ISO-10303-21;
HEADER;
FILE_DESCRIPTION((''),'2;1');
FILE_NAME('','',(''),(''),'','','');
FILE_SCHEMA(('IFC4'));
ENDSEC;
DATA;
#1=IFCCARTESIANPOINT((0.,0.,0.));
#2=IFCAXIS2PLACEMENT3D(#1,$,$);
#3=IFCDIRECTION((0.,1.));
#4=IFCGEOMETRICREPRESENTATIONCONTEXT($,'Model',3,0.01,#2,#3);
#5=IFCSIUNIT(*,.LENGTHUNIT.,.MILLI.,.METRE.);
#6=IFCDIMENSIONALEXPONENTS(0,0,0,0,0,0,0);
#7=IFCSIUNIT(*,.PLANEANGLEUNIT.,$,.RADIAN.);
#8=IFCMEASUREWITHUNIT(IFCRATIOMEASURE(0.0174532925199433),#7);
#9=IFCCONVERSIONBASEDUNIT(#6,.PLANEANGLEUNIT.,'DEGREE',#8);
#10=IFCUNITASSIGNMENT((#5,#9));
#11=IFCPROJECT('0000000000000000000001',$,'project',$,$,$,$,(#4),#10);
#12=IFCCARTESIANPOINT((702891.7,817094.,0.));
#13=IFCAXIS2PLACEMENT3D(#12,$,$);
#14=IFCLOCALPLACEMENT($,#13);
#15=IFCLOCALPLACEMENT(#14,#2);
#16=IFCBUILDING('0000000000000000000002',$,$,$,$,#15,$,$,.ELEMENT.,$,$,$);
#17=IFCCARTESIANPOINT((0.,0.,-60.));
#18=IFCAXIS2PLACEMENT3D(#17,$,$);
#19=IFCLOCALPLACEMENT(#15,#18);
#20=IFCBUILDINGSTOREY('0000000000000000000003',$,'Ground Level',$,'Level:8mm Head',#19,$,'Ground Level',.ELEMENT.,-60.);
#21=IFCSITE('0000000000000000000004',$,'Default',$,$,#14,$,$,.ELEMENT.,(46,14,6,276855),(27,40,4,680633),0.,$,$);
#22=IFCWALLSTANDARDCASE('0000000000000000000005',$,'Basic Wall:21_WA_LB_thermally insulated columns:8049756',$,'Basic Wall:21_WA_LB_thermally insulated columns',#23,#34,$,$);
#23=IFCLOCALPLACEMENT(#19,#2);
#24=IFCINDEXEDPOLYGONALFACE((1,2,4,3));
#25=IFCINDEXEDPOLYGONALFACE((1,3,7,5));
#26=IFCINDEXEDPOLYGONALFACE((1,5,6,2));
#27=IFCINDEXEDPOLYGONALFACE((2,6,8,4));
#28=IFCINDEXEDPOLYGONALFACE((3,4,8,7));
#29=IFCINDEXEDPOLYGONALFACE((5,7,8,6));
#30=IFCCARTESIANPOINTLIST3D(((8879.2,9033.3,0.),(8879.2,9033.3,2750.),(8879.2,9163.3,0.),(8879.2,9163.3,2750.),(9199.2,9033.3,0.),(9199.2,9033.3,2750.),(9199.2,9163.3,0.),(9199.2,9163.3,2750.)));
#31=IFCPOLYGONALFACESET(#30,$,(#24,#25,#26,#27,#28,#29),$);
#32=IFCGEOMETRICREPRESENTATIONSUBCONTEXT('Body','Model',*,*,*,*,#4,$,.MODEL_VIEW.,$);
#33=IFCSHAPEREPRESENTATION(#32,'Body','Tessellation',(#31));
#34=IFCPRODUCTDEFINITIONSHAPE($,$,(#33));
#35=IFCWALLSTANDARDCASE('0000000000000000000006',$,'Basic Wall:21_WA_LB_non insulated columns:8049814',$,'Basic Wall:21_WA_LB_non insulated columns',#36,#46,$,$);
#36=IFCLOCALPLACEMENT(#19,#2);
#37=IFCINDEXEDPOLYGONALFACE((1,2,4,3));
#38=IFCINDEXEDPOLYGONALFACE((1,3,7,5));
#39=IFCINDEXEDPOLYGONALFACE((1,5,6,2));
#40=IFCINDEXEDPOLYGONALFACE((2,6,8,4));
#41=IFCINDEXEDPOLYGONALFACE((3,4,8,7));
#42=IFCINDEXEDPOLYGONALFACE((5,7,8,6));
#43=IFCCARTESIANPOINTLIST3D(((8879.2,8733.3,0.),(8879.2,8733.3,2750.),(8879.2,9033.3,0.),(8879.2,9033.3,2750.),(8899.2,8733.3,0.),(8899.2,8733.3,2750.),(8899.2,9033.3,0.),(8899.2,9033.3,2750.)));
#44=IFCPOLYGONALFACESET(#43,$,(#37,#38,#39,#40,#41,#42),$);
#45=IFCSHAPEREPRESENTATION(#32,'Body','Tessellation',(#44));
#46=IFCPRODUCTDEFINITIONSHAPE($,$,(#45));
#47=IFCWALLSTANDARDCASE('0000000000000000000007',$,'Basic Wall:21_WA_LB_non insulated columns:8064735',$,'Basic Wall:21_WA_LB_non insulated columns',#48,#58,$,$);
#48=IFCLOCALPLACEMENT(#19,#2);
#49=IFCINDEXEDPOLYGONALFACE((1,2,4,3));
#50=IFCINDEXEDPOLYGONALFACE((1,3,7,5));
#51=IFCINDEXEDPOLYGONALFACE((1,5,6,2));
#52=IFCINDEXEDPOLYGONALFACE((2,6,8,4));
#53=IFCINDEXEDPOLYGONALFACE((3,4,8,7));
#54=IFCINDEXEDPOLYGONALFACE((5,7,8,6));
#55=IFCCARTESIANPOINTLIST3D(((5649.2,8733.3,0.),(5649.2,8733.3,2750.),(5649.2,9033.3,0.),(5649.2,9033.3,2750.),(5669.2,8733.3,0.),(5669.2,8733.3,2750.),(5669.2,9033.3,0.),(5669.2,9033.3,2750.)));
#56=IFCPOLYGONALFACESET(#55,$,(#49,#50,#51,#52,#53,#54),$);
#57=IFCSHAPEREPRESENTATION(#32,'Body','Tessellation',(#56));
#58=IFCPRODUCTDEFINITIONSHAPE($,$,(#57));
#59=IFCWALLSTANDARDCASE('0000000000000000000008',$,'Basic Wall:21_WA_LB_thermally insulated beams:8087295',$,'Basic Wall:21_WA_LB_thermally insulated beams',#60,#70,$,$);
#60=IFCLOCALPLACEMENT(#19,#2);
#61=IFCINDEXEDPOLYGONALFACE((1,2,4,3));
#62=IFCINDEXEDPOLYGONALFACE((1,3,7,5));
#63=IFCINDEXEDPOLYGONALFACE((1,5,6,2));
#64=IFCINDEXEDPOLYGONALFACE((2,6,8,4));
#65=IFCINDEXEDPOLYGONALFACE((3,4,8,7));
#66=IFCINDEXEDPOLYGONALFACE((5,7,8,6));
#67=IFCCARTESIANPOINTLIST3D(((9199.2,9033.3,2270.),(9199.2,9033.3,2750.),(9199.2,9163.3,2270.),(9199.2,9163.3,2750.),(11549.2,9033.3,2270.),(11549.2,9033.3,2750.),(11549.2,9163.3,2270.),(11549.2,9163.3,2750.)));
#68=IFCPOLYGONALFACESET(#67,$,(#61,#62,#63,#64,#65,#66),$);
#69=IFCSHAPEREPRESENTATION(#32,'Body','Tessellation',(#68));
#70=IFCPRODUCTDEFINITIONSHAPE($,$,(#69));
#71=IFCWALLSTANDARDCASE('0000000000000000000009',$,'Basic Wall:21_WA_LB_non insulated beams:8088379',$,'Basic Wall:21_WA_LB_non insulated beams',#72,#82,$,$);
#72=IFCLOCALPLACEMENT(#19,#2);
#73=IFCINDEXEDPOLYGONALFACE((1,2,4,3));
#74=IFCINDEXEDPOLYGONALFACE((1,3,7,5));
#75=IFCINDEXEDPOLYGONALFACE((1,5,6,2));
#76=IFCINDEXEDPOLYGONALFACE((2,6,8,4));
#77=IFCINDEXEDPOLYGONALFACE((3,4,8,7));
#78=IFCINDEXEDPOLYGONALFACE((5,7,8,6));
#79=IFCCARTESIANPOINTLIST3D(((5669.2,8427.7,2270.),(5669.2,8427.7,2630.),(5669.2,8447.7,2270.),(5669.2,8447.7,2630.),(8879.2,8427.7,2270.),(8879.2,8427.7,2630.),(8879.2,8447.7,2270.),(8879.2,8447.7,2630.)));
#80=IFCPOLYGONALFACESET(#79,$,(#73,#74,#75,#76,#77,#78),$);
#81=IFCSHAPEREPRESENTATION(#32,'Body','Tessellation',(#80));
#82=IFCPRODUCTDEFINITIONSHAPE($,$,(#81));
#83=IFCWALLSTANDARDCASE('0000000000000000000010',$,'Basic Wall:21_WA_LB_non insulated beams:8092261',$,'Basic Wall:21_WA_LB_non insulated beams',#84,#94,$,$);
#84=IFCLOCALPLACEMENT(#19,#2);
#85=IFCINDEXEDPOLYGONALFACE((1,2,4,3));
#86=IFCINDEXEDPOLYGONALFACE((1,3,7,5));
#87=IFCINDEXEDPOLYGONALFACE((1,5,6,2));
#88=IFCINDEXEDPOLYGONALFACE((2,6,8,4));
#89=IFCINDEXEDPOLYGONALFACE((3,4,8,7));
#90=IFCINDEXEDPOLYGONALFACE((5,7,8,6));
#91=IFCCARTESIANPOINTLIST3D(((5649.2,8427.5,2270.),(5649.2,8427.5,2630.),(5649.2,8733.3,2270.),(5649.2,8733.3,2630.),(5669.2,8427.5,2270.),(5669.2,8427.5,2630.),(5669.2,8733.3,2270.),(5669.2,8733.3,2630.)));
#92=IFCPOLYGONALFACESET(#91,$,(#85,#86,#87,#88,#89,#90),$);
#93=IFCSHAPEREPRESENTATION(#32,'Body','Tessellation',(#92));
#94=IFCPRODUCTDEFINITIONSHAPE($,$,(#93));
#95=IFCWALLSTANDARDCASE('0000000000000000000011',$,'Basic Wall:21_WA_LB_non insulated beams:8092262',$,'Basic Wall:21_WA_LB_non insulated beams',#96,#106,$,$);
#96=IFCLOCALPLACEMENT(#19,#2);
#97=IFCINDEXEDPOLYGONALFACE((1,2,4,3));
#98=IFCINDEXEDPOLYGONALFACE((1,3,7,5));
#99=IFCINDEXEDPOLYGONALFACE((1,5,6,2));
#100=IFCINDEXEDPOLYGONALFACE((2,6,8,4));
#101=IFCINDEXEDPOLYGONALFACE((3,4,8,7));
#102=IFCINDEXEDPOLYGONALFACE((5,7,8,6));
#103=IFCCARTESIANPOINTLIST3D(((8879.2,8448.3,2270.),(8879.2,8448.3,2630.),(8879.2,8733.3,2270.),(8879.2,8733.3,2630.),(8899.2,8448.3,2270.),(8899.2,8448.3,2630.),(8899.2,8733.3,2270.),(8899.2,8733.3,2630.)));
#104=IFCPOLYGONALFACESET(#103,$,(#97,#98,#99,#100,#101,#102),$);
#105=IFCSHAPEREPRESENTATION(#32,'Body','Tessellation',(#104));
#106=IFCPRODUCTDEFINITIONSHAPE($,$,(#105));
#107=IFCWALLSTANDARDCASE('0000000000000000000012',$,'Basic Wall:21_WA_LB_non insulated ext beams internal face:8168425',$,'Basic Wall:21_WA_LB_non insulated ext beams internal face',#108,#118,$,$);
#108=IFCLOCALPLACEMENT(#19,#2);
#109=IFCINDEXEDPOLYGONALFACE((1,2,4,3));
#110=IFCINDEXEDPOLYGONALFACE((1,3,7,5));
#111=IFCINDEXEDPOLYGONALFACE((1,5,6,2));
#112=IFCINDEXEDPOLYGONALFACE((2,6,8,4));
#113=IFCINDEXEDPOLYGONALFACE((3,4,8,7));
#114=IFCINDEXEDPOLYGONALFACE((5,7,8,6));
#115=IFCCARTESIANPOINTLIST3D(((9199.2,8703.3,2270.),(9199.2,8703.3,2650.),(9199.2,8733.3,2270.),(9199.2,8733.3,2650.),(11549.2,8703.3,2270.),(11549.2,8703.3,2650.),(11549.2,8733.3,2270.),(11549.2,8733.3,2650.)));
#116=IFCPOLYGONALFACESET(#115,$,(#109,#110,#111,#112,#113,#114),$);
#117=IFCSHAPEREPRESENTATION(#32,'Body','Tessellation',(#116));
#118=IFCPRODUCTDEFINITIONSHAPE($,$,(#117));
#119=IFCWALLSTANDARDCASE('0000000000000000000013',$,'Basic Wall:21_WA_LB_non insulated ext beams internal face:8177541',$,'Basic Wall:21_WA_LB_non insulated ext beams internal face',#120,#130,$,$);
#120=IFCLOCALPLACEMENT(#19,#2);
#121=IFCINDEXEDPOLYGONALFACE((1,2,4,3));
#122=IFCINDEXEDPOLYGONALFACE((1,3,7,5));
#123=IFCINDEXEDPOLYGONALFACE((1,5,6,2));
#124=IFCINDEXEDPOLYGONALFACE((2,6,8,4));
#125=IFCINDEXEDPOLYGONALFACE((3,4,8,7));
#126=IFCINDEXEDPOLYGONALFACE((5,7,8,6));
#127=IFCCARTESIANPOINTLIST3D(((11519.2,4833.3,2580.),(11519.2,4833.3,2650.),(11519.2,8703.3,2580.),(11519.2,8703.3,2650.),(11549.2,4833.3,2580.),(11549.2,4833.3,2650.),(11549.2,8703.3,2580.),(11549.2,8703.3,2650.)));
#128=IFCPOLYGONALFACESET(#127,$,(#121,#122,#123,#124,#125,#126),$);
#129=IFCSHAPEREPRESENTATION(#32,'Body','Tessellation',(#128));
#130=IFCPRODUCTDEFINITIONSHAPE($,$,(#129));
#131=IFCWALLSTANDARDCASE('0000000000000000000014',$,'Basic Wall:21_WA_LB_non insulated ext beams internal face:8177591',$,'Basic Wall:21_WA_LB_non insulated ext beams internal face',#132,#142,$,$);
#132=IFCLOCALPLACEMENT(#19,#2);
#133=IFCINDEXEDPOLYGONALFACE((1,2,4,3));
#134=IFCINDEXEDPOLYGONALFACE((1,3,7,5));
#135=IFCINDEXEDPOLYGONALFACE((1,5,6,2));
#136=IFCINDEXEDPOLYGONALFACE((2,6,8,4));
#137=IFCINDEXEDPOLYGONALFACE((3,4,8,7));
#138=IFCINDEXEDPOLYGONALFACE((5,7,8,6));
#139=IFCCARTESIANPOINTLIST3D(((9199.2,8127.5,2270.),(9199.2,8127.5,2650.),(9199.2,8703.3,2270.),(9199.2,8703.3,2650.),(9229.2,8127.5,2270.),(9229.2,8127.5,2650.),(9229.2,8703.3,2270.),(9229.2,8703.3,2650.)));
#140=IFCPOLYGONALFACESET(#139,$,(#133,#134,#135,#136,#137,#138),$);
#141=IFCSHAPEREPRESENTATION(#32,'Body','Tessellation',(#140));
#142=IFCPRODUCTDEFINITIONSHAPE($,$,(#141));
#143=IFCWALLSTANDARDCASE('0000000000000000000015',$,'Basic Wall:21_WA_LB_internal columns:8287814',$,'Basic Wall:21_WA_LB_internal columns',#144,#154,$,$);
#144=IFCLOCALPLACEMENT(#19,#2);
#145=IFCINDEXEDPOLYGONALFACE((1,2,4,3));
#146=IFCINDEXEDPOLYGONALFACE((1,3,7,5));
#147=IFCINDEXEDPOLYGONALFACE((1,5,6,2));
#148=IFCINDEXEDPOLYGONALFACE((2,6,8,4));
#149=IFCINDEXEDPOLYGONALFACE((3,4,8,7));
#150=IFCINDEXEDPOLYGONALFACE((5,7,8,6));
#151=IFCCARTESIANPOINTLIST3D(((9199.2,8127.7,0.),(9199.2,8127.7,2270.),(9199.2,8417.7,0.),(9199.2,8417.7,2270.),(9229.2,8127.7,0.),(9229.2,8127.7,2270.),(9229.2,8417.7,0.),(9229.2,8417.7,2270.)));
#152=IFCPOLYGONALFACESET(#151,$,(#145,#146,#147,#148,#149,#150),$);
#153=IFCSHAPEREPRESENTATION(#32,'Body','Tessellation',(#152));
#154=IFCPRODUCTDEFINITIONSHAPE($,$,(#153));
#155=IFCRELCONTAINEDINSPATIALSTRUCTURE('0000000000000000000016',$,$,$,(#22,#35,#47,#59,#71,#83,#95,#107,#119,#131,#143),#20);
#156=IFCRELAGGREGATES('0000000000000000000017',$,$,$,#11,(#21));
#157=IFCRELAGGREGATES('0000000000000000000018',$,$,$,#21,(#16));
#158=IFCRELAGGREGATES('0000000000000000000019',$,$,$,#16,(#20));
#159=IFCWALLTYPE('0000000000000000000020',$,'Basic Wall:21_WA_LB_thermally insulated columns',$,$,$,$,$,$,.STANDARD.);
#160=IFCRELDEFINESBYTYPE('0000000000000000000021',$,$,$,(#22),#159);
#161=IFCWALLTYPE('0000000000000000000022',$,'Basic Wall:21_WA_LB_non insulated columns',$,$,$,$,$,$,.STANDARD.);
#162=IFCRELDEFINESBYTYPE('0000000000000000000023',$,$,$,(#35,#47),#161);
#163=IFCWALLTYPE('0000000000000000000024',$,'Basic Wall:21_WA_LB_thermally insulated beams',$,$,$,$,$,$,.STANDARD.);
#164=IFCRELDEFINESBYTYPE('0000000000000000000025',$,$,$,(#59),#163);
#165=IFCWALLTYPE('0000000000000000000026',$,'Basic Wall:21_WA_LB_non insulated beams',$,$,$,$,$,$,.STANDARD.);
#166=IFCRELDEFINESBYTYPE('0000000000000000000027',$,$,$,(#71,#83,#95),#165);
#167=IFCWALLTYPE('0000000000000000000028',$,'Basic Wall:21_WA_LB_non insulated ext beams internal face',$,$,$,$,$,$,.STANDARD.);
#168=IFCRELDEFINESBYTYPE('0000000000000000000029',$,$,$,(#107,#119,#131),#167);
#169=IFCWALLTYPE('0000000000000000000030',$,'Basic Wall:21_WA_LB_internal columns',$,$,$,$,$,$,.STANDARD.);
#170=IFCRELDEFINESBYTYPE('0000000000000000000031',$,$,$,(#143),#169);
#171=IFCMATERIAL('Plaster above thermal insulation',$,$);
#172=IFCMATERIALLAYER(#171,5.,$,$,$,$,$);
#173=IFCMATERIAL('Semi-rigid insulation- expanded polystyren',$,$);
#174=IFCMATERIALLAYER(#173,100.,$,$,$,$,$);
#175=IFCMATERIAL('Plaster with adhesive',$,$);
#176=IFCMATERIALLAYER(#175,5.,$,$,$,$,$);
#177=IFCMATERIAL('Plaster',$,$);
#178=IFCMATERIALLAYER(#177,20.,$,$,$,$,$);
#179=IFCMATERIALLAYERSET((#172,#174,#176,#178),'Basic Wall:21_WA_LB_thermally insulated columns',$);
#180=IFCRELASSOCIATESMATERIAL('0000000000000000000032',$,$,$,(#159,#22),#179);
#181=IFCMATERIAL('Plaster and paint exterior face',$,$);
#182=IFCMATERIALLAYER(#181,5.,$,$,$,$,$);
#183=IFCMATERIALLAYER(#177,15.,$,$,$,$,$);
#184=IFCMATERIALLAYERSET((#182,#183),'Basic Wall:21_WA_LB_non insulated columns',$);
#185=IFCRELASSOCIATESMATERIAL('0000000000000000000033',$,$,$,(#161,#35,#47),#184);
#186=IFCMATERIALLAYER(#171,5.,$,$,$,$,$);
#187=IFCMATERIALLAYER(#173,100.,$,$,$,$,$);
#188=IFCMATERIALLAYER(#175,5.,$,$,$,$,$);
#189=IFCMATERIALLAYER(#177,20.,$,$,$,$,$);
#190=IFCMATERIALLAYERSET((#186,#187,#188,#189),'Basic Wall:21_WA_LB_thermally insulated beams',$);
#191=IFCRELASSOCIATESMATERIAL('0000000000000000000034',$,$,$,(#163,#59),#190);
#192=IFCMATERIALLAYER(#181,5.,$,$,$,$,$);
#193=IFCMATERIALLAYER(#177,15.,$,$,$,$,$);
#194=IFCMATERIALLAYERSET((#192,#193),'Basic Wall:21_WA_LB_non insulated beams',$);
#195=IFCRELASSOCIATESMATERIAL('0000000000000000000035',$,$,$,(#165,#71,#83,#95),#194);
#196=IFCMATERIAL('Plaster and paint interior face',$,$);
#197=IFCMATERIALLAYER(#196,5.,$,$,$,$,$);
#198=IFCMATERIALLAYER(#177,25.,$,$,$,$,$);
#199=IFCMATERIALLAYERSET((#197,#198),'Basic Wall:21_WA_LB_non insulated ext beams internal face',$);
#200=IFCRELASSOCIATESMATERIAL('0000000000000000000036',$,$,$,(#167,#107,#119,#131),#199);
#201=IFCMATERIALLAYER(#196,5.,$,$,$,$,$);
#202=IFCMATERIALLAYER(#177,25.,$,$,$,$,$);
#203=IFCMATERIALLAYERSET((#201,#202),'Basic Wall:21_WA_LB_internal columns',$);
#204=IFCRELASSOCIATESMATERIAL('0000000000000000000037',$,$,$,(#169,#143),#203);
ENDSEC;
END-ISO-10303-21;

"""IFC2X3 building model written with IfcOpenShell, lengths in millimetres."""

from ifc_helpers import new_model, entity, si_unit, converted_unit, direction, frame, frame_2d, origin, place, context, subcontext, project, spatial, rectangle, extrude, clip, halfspace, material, layer, layer_set, layer_usage, type_object, element, save


model = new_model("IFC2X3")

# Units and contexts
model_context = context("Model", 3, precision=0.01, world=origin(), true_north=direction((0.0, 1.0)))
body_context = subcontext(model_context, "Body", "Model", "MODEL_VIEW")
ifc_project = project(units=[si_unit("LENGTHUNIT", "METRE", prefix="MILLI"), converted_unit("PLANEANGLEUNIT", "DEGREE", entity("IfcRatioMeasure", 0.0174532925199433), si_unit("PLANEANGLEUNIT", "RADIAN"), dimensions=[0, 0, 0, 0, 0, 0, 0])], contexts=[model_context])

# Site, building, storey
site_placement = place(None, frame((702891.7, 817094.0, 0.0)))
site = spatial("IfcSite", under=ifc_project, at=site_placement, Name="Default", CompositionType="ELEMENT", RefLatitude=(46, 14, 6, 276855), RefLongitude=(27, 40, 4, 680633), RefElevation=0.0)
building_placement = place(site_placement, origin())
building = spatial("IfcBuilding", under=site, at=building_placement, CompositionType="ELEMENT")
storey_placement = place(building_placement, frame((0.0, 0.0, -60.0)))
storey = spatial("IfcBuildingStorey", under=building, at=storey_placement, Name="Ground Level", ObjectType="Level:8mm Head", LongName="Ground Level", CompositionType="ELEMENT", Elevation=-60.0)

# Shared definitions
ifc_material_1 = material(Name="Plaster above thermal insulation")
ifc_material_2 = material(Name="Semi-rigid insulation- expanded polystyren")
ifc_material_3 = material(Name="Plaster with adhesive")
ifc_material_4 = material(Name="Plaster")
ifc_material_5 = material(Name="Plaster and paint interior face")

# Shared definitions
ifc_material_6 = material(Name="Plaster and paint exterior face")

# Walls
ifc_layer_1 = layer(ifc_material_1, 5.0)
ifc_layer_2 = layer(ifc_material_2, 100.0)
ifc_layer_3 = layer(ifc_material_3, 5.0)
ifc_layer_4 = layer(ifc_material_4, 20.0)
ifc_layer_set_1 = layer_set([ifc_layer_1, ifc_layer_2, ifc_layer_3, ifc_layer_4], Name="Basic Wall:21_WA_LB_thermally insulated columns")
wall_type_1 = type_object("IfcWallType", Name="Basic Wall:21_WA_LB_thermally insulated columns", PredefinedType="STANDARD", material=ifc_layer_set_1)
ifc_layer_usage_1 = layer_usage(ifc_layer_set_1, "AXIS2", "NEGATIVE", 65.0)
wall_1_placement = place(storey_placement, frame((8879.2, 9098.3, 0.0)))
element("IfcWallStandardCase", 1, at=wall_1_placement, inside=storey, type_object=wall_type_1, material=ifc_layer_usage_1, Name="Basic Wall:21_WA_LB_thermally insulated columns:8049756", ObjectType="Basic Wall:21_WA_LB_thermally insulated columns", context=body_context, shape_type="Clipping", body=[
    clip(extrude(rectangle(XDim=320.0, YDim=130.0, at=frame_2d((160.0, 0.0), x_axis=(-1.0, 0.0))), origin(), (0.0, 0.0, 1.0), 2750.0), halfspace(origin(), True)),
])
ifc_layer_5 = layer(ifc_material_6, 5.0)
ifc_layer_6 = layer(ifc_material_4, 15.0)
ifc_layer_set_2 = layer_set([ifc_layer_5, ifc_layer_6], Name="Basic Wall:21_WA_LB_non insulated columns")
ifc_layer_usage_2 = layer_usage(ifc_layer_set_2, "AXIS2", "NEGATIVE", 10.0)
wall_type_2 = type_object("IfcWallType", Name="Basic Wall:21_WA_LB_non insulated columns", PredefinedType="STANDARD", material=ifc_layer_set_2)
wall_2_placement = place(storey_placement, frame((8889.2, 8733.3, 0.0), z_axis=(0.0, 0.0, 1.0), x_axis=(0.0, 1.0, 0.0)))
element("IfcWallStandardCase", 2, at=wall_2_placement, inside=storey, type_object=wall_type_2, material=ifc_layer_usage_2, Name="Basic Wall:21_WA_LB_non insulated columns:8049814", ObjectType="Basic Wall:21_WA_LB_non insulated columns", context=body_context, shape_type="Clipping", body=[
    clip(extrude(rectangle(XDim=300.0, YDim=20.0, at=frame_2d((150.0, 0.0), x_axis=(-1.0, 0.0))), origin(), (0.0, 0.0, 1.0), 2750.0), halfspace(origin(), True)),
])
ifc_layer_usage_3 = layer_usage(ifc_layer_set_2, "AXIS2", "NEGATIVE", 10.0)
wall_3_placement = place(storey_placement, frame((5659.2, 9033.3, 0.0), z_axis=(0.0, 0.0, 1.0), x_axis=(0.0, -1.0, 0.0)))
element("IfcWallStandardCase", 3, at=wall_3_placement, inside=storey, type_object=wall_type_2, material=ifc_layer_usage_3, Name="Basic Wall:21_WA_LB_non insulated columns:8064735", ObjectType="Basic Wall:21_WA_LB_non insulated columns", context=body_context, shape_type="Clipping", body=[
    clip(extrude(rectangle(XDim=300.0, YDim=20.0, at=frame_2d((150.0, 0.0), x_axis=(-1.0, 0.0))), origin(), (0.0, 0.0, 1.0), 2750.0), halfspace(origin(), True)),
])
ifc_layer_7 = layer(ifc_material_1, 5.0)
ifc_layer_8 = layer(ifc_material_2, 100.0)
ifc_layer_9 = layer(ifc_material_3, 5.0)
ifc_layer_10 = layer(ifc_material_4, 20.0)
ifc_layer_set_3 = layer_set([ifc_layer_7, ifc_layer_8, ifc_layer_9, ifc_layer_10], Name="Basic Wall:21_WA_LB_thermally insulated beams")
ifc_layer_usage_4 = layer_usage(ifc_layer_set_3, "AXIS2", "NEGATIVE", 65.0)
wall_type_3 = type_object("IfcWallType", Name="Basic Wall:21_WA_LB_thermally insulated beams", PredefinedType="STANDARD", material=ifc_layer_set_3)
wall_4_placement = place(storey_placement, frame((9199.2, 9098.3, 2270.0)))
element("IfcWallStandardCase", 4, at=wall_4_placement, inside=storey, type_object=wall_type_3, material=ifc_layer_usage_4, Name="Basic Wall:21_WA_LB_thermally insulated beams:8087295", ObjectType="Basic Wall:21_WA_LB_thermally insulated beams", context=body_context, shape_type="SweptSolid", body=[
    extrude(rectangle(XDim=2350.0, YDim=130.0, at=frame_2d((1175.0, 0.0), x_axis=(-1.0, 0.0))), origin(), (0.0, 0.0, 1.0), 480.0),
])
ifc_layer_11 = layer(ifc_material_6, 5.0)
ifc_layer_12 = layer(ifc_material_4, 15.0)
ifc_layer_set_4 = layer_set([ifc_layer_11, ifc_layer_12], Name="Basic Wall:21_WA_LB_non insulated beams")
ifc_layer_usage_5 = layer_usage(ifc_layer_set_4, "AXIS2", "NEGATIVE", 10.0)
wall_type_4 = type_object("IfcWallType", Name="Basic Wall:21_WA_LB_non insulated beams", PredefinedType="STANDARD", material=ifc_layer_set_4)
wall_5_placement = place(storey_placement, frame((5669.2, 8437.7, 2270.0)))
element("IfcWallStandardCase", 5, at=wall_5_placement, inside=storey, type_object=wall_type_4, material=ifc_layer_usage_5, Name="Basic Wall:21_WA_LB_non insulated beams:8088379", ObjectType="Basic Wall:21_WA_LB_non insulated beams", context=body_context, shape_type="SweptSolid", body=[
    extrude(rectangle(XDim=3210.0, YDim=20.0, at=frame_2d((1605.0, 0.0), x_axis=(-1.0, 0.0))), origin(), (0.0, 0.0, 1.0), 360.0),
])
ifc_layer_usage_6 = layer_usage(ifc_layer_set_4, "AXIS2", "NEGATIVE", 10.0)
wall_6_placement = place(storey_placement, frame((5659.2, 8733.3, 2270.0), z_axis=(0.0, 0.0, 1.0), x_axis=(0.0, -1.0, 0.0)))
element("IfcWallStandardCase", 6, at=wall_6_placement, inside=storey, type_object=wall_type_4, material=ifc_layer_usage_6, Name="Basic Wall:21_WA_LB_non insulated beams:8092261", ObjectType="Basic Wall:21_WA_LB_non insulated beams", context=body_context, shape_type="SweptSolid", body=[
    extrude(rectangle(XDim=305.8, YDim=20.0, at=frame_2d((152.9, 0.0), x_axis=(-1.0, 0.0))), origin(), (0.0, 0.0, 1.0), 360.0),
])
ifc_layer_usage_7 = layer_usage(ifc_layer_set_4, "AXIS2", "POSITIVE", -10.0)
wall_7_placement = place(storey_placement, frame((8889.2, 8733.3, 2270.0), z_axis=(0.0, 0.0, 1.0), x_axis=(0.0, -1.0, 0.0)))
element("IfcWallStandardCase", 7, at=wall_7_placement, inside=storey, type_object=wall_type_4, material=ifc_layer_usage_7, Name="Basic Wall:21_WA_LB_non insulated beams:8092262", ObjectType="Basic Wall:21_WA_LB_non insulated beams", context=body_context, shape_type="SweptSolid", body=[
    extrude(rectangle(XDim=285.0, YDim=20.0, at=frame_2d((142.5, 0.0), x_axis=(-1.0, 0.0))), origin(), (0.0, 0.0, 1.0), 360.0),
])
ifc_layer_13 = layer(ifc_material_5, 5.0)
ifc_layer_14 = layer(ifc_material_4, 25.0)
ifc_layer_set_5 = layer_set([ifc_layer_13, ifc_layer_14], Name="Basic Wall:21_WA_LB_non insulated ext beams internal face")
ifc_layer_usage_8 = layer_usage(ifc_layer_set_5, "AXIS2", "POSITIVE", -15.0)
wall_type_5 = type_object("IfcWallType", Name="Basic Wall:21_WA_LB_non insulated ext beams internal face", PredefinedType="STANDARD", material=ifc_layer_set_5)
wall_8_placement = place(storey_placement, frame((9199.2, 8718.3, 2270.0)))
element("IfcWallStandardCase", 8, at=wall_8_placement, inside=storey, type_object=wall_type_5, material=ifc_layer_usage_8, Name="Basic Wall:21_WA_LB_non insulated ext beams internal face:8168425", ObjectType="Basic Wall:21_WA_LB_non insulated ext beams internal face", context=body_context, shape_type="SweptSolid", body=[
    extrude(rectangle(XDim=2350.0, YDim=30.0, at=frame_2d((1175.0, 0.0), x_axis=(-1.0, 0.0))), origin(), (0.0, 0.0, 1.0), 380.0),
])
ifc_layer_usage_9 = layer_usage(ifc_layer_set_5, "AXIS2", "NEGATIVE", 15.0)
wall_9_placement = place(storey_placement, frame((11534.2, 4833.3, 2580.0), z_axis=(0.0, 0.0, 1.0), x_axis=(0.0, 1.0, 0.0)))
element("IfcWallStandardCase", 9, at=wall_9_placement, inside=storey, type_object=wall_type_5, material=ifc_layer_usage_9, Name="Basic Wall:21_WA_LB_non insulated ext beams internal face:8177541", ObjectType="Basic Wall:21_WA_LB_non insulated ext beams internal face", context=body_context, shape_type="SweptSolid", body=[
    extrude(rectangle(XDim=3870.0, YDim=30.0, at=frame_2d((1935.0, 0.0), x_axis=(-1.0, 0.0))), origin(), (0.0, 0.0, 1.0), 70.0),
])
ifc_layer_usage_10 = layer_usage(ifc_layer_set_5, "AXIS2", "POSITIVE", -15.0)
wall_10_placement = place(storey_placement, frame((9214.2, 8127.5, 2270.0), z_axis=(0.0, 0.0, 1.0), x_axis=(0.0, 1.0, 0.0)))
element("IfcWallStandardCase", 10, at=wall_10_placement, inside=storey, type_object=wall_type_5, material=ifc_layer_usage_10, Name="Basic Wall:21_WA_LB_non insulated ext beams internal face:8177591", ObjectType="Basic Wall:21_WA_LB_non insulated ext beams internal face", context=body_context, shape_type="SweptSolid", body=[
    extrude(rectangle(XDim=575.8, YDim=30.0, at=frame_2d((287.9, 0.0), x_axis=(-1.0, 0.0))), origin(), (0.0, 0.0, 1.0), 380.0),
])
ifc_layer_15 = layer(ifc_material_5, 5.0)
ifc_layer_16 = layer(ifc_material_4, 25.0)
ifc_layer_set_6 = layer_set([ifc_layer_15, ifc_layer_16], Name="Basic Wall:21_WA_LB_internal columns")
ifc_layer_usage_11 = layer_usage(ifc_layer_set_6, "AXIS2", "NEGATIVE", 15.0)
wall_type_6 = type_object("IfcWallType", Name="Basic Wall:21_WA_LB_internal columns", PredefinedType="STANDARD", material=ifc_layer_set_6)
wall_11_placement = place(storey_placement, frame((9214.2, 8417.7, 0.0), z_axis=(0.0, 0.0, 1.0), x_axis=(0.0, -1.0, 0.0)))
element("IfcWallStandardCase", 11, at=wall_11_placement, inside=storey, type_object=wall_type_6, material=ifc_layer_usage_11, Name="Basic Wall:21_WA_LB_internal columns:8287814", ObjectType="Basic Wall:21_WA_LB_internal columns", context=body_context, shape_type="SweptSolid", body=[
    extrude(rectangle(XDim=290.0, YDim=30.0, at=frame_2d((145.0, 0.0), x_axis=(-1.0, 0.0))), origin(), (0.0, 0.0, 1.0), 2270.0),
])

save(model, "model.ifc")
